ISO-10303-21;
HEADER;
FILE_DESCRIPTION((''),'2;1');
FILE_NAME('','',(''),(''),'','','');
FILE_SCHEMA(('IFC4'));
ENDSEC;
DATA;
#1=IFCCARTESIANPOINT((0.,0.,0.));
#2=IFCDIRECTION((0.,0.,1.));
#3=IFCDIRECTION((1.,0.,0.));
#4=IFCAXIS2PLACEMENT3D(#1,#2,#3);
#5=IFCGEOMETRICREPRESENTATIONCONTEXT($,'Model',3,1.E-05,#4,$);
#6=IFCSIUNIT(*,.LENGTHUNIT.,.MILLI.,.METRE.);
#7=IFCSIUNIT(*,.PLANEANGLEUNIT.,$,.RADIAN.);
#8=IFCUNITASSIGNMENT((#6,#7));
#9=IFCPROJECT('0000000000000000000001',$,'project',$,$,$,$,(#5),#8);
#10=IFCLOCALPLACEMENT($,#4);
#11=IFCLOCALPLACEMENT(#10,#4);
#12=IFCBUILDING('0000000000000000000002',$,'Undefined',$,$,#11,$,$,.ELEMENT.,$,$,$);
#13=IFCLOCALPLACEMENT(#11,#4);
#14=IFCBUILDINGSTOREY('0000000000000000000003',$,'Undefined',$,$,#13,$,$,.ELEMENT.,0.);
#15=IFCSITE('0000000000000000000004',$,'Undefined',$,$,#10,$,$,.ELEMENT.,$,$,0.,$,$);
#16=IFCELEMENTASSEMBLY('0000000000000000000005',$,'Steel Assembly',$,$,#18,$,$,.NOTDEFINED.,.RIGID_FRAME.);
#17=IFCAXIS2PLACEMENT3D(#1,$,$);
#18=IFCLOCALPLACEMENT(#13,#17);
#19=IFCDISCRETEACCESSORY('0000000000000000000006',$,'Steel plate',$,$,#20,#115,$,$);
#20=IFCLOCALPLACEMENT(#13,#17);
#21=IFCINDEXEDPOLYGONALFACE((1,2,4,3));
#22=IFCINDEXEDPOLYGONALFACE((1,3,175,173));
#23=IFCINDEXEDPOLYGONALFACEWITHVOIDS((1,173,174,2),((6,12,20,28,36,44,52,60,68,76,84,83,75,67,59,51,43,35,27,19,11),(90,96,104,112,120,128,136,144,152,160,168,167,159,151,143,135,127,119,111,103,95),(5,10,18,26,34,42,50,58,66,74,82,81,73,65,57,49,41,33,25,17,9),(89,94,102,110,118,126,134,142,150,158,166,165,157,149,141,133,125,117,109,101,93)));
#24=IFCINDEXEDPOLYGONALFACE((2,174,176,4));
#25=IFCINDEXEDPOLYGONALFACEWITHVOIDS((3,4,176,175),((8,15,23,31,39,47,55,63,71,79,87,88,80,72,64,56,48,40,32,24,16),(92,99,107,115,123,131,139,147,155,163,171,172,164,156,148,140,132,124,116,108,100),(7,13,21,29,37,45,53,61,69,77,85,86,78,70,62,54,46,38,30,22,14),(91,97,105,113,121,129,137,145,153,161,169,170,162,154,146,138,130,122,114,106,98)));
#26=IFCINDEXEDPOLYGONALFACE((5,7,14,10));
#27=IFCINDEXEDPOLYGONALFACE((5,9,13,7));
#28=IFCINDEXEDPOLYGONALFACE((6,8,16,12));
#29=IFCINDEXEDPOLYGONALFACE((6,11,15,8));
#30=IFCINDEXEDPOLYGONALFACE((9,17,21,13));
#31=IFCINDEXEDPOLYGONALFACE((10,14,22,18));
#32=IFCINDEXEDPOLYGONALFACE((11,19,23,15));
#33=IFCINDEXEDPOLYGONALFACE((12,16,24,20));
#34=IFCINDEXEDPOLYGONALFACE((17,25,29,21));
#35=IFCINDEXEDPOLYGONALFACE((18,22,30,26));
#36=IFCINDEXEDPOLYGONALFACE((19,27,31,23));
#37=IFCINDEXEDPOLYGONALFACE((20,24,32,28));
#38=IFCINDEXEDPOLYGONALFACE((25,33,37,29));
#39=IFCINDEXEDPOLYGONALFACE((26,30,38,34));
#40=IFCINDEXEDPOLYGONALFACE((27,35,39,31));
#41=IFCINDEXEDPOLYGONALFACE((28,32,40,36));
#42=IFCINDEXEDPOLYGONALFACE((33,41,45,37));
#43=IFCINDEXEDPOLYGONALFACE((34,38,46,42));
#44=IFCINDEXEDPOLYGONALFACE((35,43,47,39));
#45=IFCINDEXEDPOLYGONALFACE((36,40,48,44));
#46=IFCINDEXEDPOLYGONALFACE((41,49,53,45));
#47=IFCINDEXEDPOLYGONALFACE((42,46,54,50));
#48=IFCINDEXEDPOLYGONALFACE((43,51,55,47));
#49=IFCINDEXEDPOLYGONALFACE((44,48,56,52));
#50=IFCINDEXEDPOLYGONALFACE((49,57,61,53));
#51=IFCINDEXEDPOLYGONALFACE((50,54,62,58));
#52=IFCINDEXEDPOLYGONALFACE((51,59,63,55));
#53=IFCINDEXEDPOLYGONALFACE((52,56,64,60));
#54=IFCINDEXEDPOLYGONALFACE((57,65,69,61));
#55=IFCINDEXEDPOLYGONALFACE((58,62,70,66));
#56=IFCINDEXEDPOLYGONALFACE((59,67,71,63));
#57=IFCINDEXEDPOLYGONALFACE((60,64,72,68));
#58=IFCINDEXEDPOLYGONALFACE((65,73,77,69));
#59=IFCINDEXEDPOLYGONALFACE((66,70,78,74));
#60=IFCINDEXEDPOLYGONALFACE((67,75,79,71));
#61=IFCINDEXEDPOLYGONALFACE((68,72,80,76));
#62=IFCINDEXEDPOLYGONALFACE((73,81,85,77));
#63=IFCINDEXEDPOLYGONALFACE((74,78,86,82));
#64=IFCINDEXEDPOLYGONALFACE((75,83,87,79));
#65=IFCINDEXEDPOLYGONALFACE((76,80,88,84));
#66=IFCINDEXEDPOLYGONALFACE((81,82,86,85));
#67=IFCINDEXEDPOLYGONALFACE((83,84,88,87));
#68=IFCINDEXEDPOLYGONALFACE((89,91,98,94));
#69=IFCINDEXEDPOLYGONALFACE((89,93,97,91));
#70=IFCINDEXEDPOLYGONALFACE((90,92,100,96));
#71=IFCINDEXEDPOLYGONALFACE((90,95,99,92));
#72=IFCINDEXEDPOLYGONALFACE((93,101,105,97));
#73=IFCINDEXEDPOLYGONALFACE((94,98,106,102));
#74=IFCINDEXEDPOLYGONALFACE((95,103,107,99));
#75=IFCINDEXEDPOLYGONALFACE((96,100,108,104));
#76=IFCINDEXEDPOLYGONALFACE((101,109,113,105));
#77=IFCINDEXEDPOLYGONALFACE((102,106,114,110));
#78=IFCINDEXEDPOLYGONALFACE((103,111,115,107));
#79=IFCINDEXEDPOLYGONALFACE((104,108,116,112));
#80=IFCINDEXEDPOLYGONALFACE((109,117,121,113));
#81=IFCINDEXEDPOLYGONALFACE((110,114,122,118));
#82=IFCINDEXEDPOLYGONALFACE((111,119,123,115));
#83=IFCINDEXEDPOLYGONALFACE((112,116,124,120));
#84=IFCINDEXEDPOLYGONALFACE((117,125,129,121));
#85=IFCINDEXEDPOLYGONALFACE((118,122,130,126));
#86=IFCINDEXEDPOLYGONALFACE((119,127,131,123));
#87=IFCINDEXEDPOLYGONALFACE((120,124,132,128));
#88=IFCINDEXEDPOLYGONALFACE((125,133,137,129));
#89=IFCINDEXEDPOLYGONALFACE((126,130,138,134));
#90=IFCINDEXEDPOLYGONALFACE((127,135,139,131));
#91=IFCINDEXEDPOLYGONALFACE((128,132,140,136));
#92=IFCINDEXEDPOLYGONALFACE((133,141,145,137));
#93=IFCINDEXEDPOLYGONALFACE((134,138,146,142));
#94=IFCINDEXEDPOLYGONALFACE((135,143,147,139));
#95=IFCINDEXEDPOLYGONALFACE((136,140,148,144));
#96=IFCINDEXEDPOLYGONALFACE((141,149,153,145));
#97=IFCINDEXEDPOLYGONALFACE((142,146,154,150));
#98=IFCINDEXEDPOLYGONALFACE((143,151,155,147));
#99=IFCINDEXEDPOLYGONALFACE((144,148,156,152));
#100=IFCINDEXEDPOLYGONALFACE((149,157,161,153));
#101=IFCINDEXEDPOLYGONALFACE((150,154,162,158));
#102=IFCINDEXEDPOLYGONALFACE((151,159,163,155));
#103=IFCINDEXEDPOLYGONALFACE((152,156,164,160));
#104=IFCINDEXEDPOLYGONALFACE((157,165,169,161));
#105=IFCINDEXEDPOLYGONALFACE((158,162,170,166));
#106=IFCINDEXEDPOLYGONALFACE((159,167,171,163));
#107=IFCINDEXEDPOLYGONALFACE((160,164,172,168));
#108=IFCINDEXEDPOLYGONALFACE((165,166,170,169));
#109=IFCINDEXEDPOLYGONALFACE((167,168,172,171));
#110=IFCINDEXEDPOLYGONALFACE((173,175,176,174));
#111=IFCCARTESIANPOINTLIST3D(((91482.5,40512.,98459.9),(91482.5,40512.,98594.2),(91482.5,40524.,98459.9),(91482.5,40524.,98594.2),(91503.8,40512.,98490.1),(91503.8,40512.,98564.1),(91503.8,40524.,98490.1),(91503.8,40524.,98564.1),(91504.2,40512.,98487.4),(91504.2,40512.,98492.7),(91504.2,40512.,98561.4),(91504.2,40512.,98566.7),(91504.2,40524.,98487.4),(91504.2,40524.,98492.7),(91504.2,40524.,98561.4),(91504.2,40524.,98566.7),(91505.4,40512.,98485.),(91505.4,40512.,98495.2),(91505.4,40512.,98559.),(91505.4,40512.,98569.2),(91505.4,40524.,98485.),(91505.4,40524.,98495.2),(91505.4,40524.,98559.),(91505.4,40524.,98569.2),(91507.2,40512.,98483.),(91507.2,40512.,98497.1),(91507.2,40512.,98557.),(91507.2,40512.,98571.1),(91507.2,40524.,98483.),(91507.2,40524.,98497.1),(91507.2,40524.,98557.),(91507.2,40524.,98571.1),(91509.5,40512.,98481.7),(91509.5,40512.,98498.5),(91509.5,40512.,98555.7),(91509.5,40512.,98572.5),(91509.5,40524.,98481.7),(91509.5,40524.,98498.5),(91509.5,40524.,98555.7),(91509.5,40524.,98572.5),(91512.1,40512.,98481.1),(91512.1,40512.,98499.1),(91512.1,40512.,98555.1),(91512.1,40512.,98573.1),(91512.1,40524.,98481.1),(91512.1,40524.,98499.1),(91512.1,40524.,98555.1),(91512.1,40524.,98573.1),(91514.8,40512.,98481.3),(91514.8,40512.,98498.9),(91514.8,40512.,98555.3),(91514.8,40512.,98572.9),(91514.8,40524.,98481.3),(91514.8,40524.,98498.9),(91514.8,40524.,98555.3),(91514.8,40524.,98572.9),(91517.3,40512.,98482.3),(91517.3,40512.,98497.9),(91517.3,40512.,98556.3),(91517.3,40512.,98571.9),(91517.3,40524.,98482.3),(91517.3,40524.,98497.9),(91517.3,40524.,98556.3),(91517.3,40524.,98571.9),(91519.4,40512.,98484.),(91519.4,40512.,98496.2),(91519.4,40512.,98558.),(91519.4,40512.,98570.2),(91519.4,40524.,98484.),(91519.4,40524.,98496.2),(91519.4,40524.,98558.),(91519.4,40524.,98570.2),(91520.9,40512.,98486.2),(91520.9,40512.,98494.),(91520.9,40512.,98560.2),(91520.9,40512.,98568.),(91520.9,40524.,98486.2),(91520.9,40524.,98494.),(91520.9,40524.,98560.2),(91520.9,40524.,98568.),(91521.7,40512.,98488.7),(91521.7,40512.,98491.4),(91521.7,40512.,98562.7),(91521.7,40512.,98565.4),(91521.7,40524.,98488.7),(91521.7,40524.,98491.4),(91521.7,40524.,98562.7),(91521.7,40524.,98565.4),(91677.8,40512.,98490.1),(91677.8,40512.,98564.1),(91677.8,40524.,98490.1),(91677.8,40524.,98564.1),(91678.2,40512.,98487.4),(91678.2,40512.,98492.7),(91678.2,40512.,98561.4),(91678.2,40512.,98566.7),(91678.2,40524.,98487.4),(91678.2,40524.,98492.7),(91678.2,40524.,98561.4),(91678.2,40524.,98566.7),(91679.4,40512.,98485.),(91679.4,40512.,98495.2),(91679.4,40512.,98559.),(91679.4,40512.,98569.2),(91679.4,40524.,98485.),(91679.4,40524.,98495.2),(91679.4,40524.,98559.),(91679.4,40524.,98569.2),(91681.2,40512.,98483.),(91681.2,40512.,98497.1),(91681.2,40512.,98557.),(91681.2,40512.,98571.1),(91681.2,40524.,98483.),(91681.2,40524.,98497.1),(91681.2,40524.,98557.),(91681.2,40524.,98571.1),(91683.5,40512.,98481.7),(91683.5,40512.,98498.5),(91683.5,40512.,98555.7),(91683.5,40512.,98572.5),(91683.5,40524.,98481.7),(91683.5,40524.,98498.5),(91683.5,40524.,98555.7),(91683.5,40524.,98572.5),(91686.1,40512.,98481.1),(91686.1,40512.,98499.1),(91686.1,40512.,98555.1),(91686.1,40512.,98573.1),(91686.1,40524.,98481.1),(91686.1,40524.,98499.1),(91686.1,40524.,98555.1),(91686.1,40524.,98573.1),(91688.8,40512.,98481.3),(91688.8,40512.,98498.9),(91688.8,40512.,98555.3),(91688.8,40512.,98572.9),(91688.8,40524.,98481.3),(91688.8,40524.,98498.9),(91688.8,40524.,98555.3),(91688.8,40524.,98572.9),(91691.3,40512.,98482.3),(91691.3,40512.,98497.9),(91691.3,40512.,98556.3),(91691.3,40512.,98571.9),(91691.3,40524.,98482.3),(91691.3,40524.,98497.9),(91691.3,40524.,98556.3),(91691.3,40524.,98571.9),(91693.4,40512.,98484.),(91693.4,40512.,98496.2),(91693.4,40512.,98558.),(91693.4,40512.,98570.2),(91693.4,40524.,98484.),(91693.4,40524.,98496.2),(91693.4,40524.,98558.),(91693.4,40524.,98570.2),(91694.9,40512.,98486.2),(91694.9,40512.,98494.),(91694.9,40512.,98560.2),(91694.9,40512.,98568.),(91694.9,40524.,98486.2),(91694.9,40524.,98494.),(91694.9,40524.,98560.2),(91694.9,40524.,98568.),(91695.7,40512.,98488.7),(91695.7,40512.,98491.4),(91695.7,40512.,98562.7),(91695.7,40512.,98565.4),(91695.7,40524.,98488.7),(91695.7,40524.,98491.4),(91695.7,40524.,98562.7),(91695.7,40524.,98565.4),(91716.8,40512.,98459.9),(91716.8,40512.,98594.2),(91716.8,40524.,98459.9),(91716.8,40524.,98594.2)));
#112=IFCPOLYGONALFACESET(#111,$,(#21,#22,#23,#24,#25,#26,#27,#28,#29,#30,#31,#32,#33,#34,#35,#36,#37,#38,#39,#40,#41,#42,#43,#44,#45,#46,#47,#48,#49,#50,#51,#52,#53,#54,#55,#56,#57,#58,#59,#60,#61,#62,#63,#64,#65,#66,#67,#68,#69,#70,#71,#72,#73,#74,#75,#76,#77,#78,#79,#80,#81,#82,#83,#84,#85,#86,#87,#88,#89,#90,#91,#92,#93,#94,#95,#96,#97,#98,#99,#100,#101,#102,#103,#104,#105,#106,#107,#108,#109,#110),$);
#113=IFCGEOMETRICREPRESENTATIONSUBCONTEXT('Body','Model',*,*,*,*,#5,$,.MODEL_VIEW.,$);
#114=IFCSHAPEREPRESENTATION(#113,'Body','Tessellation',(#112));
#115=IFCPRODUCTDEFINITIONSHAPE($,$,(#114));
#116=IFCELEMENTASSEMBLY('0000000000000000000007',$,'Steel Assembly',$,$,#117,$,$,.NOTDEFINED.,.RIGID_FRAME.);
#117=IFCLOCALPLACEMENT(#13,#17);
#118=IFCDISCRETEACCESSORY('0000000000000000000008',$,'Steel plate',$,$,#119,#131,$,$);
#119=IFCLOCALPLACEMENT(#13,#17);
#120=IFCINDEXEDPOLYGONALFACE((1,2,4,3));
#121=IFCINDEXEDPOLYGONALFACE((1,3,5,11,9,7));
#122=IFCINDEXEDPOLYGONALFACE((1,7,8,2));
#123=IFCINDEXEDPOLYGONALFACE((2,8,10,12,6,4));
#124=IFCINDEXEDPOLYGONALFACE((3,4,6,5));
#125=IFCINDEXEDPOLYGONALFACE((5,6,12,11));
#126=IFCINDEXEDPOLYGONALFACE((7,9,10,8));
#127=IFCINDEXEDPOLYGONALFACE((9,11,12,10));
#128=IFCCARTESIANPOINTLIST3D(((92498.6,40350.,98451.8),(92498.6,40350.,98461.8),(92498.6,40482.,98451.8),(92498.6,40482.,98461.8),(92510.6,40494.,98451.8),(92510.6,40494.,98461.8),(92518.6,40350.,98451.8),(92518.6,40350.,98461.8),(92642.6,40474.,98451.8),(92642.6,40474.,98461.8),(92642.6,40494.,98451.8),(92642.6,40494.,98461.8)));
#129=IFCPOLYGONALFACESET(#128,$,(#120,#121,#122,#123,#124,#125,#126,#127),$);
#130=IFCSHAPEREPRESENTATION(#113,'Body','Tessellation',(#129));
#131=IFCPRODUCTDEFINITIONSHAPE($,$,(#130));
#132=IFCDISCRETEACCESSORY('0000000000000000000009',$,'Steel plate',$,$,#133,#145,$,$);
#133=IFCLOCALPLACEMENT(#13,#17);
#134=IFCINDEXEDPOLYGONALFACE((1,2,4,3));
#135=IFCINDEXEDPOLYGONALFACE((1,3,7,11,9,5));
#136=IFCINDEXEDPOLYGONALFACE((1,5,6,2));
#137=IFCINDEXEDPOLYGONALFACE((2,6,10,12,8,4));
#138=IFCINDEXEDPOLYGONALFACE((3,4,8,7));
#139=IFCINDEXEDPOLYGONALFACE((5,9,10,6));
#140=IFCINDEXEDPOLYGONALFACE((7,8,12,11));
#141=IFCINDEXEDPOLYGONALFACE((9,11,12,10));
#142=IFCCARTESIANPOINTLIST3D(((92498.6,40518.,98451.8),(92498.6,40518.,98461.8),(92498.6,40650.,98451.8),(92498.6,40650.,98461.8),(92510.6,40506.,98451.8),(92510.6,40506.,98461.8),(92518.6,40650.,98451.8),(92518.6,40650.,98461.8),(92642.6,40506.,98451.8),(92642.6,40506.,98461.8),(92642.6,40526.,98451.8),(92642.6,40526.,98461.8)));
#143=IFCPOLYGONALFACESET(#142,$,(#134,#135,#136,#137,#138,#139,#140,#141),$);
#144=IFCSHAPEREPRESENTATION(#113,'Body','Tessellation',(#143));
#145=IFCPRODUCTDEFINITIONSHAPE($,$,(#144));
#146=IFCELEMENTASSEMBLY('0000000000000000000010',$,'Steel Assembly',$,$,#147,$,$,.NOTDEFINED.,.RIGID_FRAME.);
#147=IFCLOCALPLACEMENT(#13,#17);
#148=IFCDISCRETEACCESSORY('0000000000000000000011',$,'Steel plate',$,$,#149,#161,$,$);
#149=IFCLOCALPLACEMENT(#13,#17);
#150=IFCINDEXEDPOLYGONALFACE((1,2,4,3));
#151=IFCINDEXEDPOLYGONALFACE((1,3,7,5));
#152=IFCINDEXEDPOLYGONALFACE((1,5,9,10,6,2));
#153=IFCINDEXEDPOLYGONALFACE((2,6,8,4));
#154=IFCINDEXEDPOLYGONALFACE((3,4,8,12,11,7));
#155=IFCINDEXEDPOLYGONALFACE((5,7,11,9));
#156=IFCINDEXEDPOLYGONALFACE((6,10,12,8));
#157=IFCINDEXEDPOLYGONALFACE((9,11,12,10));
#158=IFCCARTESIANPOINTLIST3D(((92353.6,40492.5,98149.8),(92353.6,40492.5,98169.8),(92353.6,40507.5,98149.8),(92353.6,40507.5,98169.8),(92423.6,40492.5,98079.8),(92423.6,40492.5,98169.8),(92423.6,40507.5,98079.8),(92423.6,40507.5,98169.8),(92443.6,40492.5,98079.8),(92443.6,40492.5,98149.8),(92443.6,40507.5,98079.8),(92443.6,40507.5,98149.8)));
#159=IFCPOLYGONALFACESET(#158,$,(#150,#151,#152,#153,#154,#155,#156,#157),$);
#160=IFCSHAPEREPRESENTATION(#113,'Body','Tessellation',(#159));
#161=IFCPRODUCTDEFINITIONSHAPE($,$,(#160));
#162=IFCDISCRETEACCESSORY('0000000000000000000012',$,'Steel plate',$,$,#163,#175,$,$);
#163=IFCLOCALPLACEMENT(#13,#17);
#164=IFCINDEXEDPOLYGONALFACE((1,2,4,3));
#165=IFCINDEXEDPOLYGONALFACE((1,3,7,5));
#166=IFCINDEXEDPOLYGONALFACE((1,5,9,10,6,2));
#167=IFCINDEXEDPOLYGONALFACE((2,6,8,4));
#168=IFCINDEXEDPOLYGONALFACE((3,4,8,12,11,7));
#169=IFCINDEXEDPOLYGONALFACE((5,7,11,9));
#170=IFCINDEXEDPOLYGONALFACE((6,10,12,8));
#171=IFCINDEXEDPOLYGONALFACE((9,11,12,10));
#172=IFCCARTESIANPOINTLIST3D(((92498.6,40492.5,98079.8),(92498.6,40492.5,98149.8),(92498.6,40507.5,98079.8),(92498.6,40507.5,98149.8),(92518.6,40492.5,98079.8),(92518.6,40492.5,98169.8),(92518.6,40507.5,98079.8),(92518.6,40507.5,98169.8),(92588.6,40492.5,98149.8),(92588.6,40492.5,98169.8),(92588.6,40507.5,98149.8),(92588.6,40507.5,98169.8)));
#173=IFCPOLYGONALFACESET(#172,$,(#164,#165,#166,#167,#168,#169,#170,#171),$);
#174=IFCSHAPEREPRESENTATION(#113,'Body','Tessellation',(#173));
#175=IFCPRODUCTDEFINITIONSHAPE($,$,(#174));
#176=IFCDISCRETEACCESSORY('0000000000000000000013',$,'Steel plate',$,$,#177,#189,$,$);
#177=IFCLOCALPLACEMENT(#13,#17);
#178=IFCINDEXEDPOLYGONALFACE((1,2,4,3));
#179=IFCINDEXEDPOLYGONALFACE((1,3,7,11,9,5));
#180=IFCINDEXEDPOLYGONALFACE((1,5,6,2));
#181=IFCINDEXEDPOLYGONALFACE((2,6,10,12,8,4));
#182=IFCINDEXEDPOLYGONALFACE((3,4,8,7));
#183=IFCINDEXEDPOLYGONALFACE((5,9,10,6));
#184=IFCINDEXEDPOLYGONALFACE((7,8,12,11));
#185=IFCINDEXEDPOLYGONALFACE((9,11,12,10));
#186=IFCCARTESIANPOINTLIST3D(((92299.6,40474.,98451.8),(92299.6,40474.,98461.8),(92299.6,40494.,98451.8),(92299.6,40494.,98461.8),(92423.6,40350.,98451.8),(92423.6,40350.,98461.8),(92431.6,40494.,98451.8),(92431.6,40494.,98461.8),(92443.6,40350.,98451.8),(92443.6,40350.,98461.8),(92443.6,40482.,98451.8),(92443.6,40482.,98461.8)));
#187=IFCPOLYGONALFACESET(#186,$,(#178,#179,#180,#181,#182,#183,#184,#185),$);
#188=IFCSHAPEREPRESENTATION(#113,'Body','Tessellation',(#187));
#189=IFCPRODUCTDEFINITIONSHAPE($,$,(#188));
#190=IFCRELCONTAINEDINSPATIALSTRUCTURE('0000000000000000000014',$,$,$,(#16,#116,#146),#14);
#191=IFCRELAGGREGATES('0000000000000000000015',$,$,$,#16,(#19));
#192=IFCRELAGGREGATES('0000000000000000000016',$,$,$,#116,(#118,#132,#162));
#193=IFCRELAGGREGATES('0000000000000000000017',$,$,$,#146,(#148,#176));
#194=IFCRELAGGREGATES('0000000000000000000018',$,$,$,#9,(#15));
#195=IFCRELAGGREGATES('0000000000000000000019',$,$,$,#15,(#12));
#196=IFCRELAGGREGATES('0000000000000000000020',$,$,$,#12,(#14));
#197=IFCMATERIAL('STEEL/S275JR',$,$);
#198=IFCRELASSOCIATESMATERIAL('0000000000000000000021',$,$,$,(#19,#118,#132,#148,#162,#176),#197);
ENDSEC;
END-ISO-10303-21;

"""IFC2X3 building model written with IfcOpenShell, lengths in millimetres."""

from ifc_helpers import new_model, si_unit, frame, origin_with_axes, origin_2d_with_axis, place, context, subcontext, project, spatial, polyline, circle, outline, extrude, source, transform, mapped, material, element, aggregate, save


model = new_model("IFC2X3")

# Units and contexts
model_context = context("Model", 3, precision=1e-05, world=origin_with_axes())
body_context = subcontext(model_context, "Body", "Model", "MODEL_VIEW")
ifc_project = project(units=[si_unit("LENGTHUNIT", "METRE", prefix="MILLI"), si_unit("PLANEANGLEUNIT", "RADIAN")], contexts=[model_context])

# Site, building, storey
site_placement = place(None, origin_with_axes())
site = spatial("IfcSite", under=ifc_project, at=site_placement, Name="Undefined", CompositionType="ELEMENT", RefElevation=0.0)
building_placement = place(site_placement, origin_with_axes())
building = spatial("IfcBuilding", under=site, at=building_placement, Name="Undefined", CompositionType="ELEMENT")
storey_placement = place(building_placement, origin_with_axes())
storey = spatial("IfcBuildingStorey", under=building, at=storey_placement, Name="Undefined", CompositionType="ELEMENT", Elevation=0.0)

# Shared definitions
ifc_material_1 = material(Name="STEEL/S275JR")

# Element assembly, discrete accessory, opening
assembly_1_placement = place(storey_placement, origin_with_axes())
assembly_1 = element("IfcElementAssembly", 1, at=assembly_1_placement, inside=storey, Name="Steel Assembly", AssemblyPlace="NOTDEFINED", PredefinedType="RIGID_FRAME")
discrete_accessory_1_placement = place(assembly_1_placement, frame((91716.8, 40518.0, 98594.2), z_axis=(0.0, 1.0, 0.0), x_axis=(0.0, 0.0, -1.0)))
discrete_accessory_1 = element("IfcDiscreteAccessory", 2, at=discrete_accessory_1_placement, material=ifc_material_1, Name="Steel plate", context=body_context, shape_type="SweptSolid", body=[
    extrude(outline(polyline([(0.0, 0.0), (134.3, 0.0), (134.3, 234.3), (0.0, 234.3), (0.0, 0.0)])), frame((0.0, 0.0, -6.0), z_axis=(0.0, 0.0, 1.0), x_axis=(1.0, 0.0, 0.0)), (0.0, 0.0, 1.0), 12.0),
])
shared_shape_1 = source(origin_with_axes(), body_context, "Body", "SweptSolid", [
    extrude(circle(Radius=9.0, at=origin_2d_with_axis()), frame((0.0, -48.1, 0.0), z_axis=(0.0, 1.0, 0.0), x_axis=(1.0, 0.0, 0.0)), (0.0, 0.0, 1.0), 60.3),
])
opening_1_placement = place(assembly_1_placement, frame((91686.8, 40476.0, 98527.1), z_axis=(0.0, 0.0, 1.0), x_axis=(-1.0, 0.0, 0.0)))
element("IfcOpeningElement", 3, at=opening_1_placement, cuts=discrete_accessory_1, ObjectType="Opening", context=body_context, shape_type="MappedRepresentation", body=[
    mapped(shared_shape_1, transform((0.0, 0.0, -37.0))),
    mapped(shared_shape_1, transform((174.0, 0.0, -37.0))),
    mapped(shared_shape_1, transform((0.0, 0.0, 37.0))),
    mapped(shared_shape_1, transform((174.0, 0.0, 37.0))),
])
aggregate(assembly_1, [discrete_accessory_1])

# Element assembly, discrete accessories
assembly_2_placement = place(storey_placement, origin_with_axes())
assembly_2 = element("IfcElementAssembly", 4, at=assembly_2_placement, inside=storey, Name="Steel Assembly", AssemblyPlace="NOTDEFINED", PredefinedType="RIGID_FRAME")
discrete_accessory_2_placement = place(assembly_2_placement, frame((92498.6, 40494.0, 98456.8), z_axis=(0.0, 0.0, 1.0), x_axis=(-0.000004, -1.0, 0.0)))
discrete_accessory_2 = element("IfcDiscreteAccessory", 5, at=discrete_accessory_2_placement, material=ifc_material_1, Name="Steel plate", context=body_context, shape_type="SweptSolid", body=[
    extrude(outline(polyline([(0.0, 12.0), (12.0, 0.0), (144.0, 0.0), (144.0, 20.0), (20.0, 144.0), (0.0, 144.0), (0.0, 12.0)])), frame((0.0, 0.0, -5.0), z_axis=(0.0, 0.0, 1.0), x_axis=(1.0, 0.0, 0.0)), (0.0, 0.0, 1.0), 10.0),
])
discrete_accessory_3_placement = place(assembly_2_placement, frame((92498.6, 40506.0, 98456.8), z_axis=(0.0, 0.0, -1.0), x_axis=(-0.000003, 1.0, 0.0)))
discrete_accessory_3 = element("IfcDiscreteAccessory", 6, at=discrete_accessory_3_placement, material=ifc_material_1, Name="Steel plate", context=body_context, shape_type="SweptSolid", body=[
    extrude(outline(polyline([(0.0, 12.0), (12.0, 0.0), (144.0, 0.0), (144.0, 20.0), (20.0, 144.0), (0.0, 144.0), (0.0, 12.0)])), frame((0.0, 0.0, -5.0), z_axis=(0.0, 0.0, 1.0), x_axis=(1.0, 0.0, 0.0)), (0.0, 0.0, 1.0), 10.0),
])

# Element assembly, discrete accessory
assembly_3_placement = place(storey_placement, origin_with_axes())
assembly_3 = element("IfcElementAssembly", 7, at=assembly_3_placement, inside=storey, Name="Steel Assembly", AssemblyPlace="NOTDEFINED", PredefinedType="RIGID_FRAME")
discrete_accessory_4_placement = place(assembly_3_placement, frame((92353.6, 40500.0, 98169.8), z_axis=(0.0, 1.0, 0.0), x_axis=(1.0, 0.0, 0.0)))
discrete_accessory_4 = element("IfcDiscreteAccessory", 8, at=discrete_accessory_4_placement, material=ifc_material_1, Name="Steel plate", context=body_context, shape_type="SweptSolid", body=[
    extrude(outline(polyline([(0.0, 0.0), (70.0, 0.0), (90.0, 20.0), (90.0, 90.0), (70.0, 90.0), (0.0, 20.0), (0.0, 0.0)])), frame((0.0, 0.0, -7.5), z_axis=(0.0, 0.0, 1.0), x_axis=(1.0, 0.0, 0.0)), (0.0, 0.0, 1.0), 15.0),
])

# Discrete accessories
discrete_accessory_5_placement = place(assembly_2_placement, frame((92588.6, 40500.0, 98169.8), z_axis=(0.0, -1.0, 0.0), x_axis=(-1.0, 0.0, 0.0)))
discrete_accessory_5 = element("IfcDiscreteAccessory", 9, at=discrete_accessory_5_placement, material=ifc_material_1, Name="Steel plate", context=body_context, shape_type="SweptSolid", body=[
    extrude(outline(polyline([(0.0, 0.0), (70.0, 0.0), (90.0, 20.0), (90.0, 90.0), (70.0, 90.0), (0.0, 20.0), (0.0, 0.0)])), frame((0.0, 0.0, -7.5), z_axis=(0.0, 0.0, 1.0), x_axis=(1.0, 0.0, 0.0)), (0.0, 0.0, 1.0), 15.0),
])
discrete_accessory_6_placement = place(assembly_3_placement, frame((92443.6, 40494.0, 98456.8), z_axis=(0.0, 0.0, -1.0), x_axis=(0.000005, -1.0, 0.0)))
discrete_accessory_6 = element("IfcDiscreteAccessory", 10, at=discrete_accessory_6_placement, material=ifc_material_1, Name="Steel plate", context=body_context, shape_type="SweptSolid", body=[
    extrude(outline(polyline([(0.0, 12.0), (12.0, 0.0), (144.0, 0.0), (144.0, 20.0), (20.0, 144.0), (0.0, 144.0), (0.0, 12.0)])), frame((0.0, 0.0, -5.0), z_axis=(0.0, 0.0, 1.0), x_axis=(1.0, 0.0, 0.0)), (0.0, 0.0, 1.0), 10.0),
])

aggregate(assembly_2, [discrete_accessory_2, discrete_accessory_3, discrete_accessory_5])
aggregate(assembly_3, [discrete_accessory_4, discrete_accessory_6])

save(model, "model.ifc")
